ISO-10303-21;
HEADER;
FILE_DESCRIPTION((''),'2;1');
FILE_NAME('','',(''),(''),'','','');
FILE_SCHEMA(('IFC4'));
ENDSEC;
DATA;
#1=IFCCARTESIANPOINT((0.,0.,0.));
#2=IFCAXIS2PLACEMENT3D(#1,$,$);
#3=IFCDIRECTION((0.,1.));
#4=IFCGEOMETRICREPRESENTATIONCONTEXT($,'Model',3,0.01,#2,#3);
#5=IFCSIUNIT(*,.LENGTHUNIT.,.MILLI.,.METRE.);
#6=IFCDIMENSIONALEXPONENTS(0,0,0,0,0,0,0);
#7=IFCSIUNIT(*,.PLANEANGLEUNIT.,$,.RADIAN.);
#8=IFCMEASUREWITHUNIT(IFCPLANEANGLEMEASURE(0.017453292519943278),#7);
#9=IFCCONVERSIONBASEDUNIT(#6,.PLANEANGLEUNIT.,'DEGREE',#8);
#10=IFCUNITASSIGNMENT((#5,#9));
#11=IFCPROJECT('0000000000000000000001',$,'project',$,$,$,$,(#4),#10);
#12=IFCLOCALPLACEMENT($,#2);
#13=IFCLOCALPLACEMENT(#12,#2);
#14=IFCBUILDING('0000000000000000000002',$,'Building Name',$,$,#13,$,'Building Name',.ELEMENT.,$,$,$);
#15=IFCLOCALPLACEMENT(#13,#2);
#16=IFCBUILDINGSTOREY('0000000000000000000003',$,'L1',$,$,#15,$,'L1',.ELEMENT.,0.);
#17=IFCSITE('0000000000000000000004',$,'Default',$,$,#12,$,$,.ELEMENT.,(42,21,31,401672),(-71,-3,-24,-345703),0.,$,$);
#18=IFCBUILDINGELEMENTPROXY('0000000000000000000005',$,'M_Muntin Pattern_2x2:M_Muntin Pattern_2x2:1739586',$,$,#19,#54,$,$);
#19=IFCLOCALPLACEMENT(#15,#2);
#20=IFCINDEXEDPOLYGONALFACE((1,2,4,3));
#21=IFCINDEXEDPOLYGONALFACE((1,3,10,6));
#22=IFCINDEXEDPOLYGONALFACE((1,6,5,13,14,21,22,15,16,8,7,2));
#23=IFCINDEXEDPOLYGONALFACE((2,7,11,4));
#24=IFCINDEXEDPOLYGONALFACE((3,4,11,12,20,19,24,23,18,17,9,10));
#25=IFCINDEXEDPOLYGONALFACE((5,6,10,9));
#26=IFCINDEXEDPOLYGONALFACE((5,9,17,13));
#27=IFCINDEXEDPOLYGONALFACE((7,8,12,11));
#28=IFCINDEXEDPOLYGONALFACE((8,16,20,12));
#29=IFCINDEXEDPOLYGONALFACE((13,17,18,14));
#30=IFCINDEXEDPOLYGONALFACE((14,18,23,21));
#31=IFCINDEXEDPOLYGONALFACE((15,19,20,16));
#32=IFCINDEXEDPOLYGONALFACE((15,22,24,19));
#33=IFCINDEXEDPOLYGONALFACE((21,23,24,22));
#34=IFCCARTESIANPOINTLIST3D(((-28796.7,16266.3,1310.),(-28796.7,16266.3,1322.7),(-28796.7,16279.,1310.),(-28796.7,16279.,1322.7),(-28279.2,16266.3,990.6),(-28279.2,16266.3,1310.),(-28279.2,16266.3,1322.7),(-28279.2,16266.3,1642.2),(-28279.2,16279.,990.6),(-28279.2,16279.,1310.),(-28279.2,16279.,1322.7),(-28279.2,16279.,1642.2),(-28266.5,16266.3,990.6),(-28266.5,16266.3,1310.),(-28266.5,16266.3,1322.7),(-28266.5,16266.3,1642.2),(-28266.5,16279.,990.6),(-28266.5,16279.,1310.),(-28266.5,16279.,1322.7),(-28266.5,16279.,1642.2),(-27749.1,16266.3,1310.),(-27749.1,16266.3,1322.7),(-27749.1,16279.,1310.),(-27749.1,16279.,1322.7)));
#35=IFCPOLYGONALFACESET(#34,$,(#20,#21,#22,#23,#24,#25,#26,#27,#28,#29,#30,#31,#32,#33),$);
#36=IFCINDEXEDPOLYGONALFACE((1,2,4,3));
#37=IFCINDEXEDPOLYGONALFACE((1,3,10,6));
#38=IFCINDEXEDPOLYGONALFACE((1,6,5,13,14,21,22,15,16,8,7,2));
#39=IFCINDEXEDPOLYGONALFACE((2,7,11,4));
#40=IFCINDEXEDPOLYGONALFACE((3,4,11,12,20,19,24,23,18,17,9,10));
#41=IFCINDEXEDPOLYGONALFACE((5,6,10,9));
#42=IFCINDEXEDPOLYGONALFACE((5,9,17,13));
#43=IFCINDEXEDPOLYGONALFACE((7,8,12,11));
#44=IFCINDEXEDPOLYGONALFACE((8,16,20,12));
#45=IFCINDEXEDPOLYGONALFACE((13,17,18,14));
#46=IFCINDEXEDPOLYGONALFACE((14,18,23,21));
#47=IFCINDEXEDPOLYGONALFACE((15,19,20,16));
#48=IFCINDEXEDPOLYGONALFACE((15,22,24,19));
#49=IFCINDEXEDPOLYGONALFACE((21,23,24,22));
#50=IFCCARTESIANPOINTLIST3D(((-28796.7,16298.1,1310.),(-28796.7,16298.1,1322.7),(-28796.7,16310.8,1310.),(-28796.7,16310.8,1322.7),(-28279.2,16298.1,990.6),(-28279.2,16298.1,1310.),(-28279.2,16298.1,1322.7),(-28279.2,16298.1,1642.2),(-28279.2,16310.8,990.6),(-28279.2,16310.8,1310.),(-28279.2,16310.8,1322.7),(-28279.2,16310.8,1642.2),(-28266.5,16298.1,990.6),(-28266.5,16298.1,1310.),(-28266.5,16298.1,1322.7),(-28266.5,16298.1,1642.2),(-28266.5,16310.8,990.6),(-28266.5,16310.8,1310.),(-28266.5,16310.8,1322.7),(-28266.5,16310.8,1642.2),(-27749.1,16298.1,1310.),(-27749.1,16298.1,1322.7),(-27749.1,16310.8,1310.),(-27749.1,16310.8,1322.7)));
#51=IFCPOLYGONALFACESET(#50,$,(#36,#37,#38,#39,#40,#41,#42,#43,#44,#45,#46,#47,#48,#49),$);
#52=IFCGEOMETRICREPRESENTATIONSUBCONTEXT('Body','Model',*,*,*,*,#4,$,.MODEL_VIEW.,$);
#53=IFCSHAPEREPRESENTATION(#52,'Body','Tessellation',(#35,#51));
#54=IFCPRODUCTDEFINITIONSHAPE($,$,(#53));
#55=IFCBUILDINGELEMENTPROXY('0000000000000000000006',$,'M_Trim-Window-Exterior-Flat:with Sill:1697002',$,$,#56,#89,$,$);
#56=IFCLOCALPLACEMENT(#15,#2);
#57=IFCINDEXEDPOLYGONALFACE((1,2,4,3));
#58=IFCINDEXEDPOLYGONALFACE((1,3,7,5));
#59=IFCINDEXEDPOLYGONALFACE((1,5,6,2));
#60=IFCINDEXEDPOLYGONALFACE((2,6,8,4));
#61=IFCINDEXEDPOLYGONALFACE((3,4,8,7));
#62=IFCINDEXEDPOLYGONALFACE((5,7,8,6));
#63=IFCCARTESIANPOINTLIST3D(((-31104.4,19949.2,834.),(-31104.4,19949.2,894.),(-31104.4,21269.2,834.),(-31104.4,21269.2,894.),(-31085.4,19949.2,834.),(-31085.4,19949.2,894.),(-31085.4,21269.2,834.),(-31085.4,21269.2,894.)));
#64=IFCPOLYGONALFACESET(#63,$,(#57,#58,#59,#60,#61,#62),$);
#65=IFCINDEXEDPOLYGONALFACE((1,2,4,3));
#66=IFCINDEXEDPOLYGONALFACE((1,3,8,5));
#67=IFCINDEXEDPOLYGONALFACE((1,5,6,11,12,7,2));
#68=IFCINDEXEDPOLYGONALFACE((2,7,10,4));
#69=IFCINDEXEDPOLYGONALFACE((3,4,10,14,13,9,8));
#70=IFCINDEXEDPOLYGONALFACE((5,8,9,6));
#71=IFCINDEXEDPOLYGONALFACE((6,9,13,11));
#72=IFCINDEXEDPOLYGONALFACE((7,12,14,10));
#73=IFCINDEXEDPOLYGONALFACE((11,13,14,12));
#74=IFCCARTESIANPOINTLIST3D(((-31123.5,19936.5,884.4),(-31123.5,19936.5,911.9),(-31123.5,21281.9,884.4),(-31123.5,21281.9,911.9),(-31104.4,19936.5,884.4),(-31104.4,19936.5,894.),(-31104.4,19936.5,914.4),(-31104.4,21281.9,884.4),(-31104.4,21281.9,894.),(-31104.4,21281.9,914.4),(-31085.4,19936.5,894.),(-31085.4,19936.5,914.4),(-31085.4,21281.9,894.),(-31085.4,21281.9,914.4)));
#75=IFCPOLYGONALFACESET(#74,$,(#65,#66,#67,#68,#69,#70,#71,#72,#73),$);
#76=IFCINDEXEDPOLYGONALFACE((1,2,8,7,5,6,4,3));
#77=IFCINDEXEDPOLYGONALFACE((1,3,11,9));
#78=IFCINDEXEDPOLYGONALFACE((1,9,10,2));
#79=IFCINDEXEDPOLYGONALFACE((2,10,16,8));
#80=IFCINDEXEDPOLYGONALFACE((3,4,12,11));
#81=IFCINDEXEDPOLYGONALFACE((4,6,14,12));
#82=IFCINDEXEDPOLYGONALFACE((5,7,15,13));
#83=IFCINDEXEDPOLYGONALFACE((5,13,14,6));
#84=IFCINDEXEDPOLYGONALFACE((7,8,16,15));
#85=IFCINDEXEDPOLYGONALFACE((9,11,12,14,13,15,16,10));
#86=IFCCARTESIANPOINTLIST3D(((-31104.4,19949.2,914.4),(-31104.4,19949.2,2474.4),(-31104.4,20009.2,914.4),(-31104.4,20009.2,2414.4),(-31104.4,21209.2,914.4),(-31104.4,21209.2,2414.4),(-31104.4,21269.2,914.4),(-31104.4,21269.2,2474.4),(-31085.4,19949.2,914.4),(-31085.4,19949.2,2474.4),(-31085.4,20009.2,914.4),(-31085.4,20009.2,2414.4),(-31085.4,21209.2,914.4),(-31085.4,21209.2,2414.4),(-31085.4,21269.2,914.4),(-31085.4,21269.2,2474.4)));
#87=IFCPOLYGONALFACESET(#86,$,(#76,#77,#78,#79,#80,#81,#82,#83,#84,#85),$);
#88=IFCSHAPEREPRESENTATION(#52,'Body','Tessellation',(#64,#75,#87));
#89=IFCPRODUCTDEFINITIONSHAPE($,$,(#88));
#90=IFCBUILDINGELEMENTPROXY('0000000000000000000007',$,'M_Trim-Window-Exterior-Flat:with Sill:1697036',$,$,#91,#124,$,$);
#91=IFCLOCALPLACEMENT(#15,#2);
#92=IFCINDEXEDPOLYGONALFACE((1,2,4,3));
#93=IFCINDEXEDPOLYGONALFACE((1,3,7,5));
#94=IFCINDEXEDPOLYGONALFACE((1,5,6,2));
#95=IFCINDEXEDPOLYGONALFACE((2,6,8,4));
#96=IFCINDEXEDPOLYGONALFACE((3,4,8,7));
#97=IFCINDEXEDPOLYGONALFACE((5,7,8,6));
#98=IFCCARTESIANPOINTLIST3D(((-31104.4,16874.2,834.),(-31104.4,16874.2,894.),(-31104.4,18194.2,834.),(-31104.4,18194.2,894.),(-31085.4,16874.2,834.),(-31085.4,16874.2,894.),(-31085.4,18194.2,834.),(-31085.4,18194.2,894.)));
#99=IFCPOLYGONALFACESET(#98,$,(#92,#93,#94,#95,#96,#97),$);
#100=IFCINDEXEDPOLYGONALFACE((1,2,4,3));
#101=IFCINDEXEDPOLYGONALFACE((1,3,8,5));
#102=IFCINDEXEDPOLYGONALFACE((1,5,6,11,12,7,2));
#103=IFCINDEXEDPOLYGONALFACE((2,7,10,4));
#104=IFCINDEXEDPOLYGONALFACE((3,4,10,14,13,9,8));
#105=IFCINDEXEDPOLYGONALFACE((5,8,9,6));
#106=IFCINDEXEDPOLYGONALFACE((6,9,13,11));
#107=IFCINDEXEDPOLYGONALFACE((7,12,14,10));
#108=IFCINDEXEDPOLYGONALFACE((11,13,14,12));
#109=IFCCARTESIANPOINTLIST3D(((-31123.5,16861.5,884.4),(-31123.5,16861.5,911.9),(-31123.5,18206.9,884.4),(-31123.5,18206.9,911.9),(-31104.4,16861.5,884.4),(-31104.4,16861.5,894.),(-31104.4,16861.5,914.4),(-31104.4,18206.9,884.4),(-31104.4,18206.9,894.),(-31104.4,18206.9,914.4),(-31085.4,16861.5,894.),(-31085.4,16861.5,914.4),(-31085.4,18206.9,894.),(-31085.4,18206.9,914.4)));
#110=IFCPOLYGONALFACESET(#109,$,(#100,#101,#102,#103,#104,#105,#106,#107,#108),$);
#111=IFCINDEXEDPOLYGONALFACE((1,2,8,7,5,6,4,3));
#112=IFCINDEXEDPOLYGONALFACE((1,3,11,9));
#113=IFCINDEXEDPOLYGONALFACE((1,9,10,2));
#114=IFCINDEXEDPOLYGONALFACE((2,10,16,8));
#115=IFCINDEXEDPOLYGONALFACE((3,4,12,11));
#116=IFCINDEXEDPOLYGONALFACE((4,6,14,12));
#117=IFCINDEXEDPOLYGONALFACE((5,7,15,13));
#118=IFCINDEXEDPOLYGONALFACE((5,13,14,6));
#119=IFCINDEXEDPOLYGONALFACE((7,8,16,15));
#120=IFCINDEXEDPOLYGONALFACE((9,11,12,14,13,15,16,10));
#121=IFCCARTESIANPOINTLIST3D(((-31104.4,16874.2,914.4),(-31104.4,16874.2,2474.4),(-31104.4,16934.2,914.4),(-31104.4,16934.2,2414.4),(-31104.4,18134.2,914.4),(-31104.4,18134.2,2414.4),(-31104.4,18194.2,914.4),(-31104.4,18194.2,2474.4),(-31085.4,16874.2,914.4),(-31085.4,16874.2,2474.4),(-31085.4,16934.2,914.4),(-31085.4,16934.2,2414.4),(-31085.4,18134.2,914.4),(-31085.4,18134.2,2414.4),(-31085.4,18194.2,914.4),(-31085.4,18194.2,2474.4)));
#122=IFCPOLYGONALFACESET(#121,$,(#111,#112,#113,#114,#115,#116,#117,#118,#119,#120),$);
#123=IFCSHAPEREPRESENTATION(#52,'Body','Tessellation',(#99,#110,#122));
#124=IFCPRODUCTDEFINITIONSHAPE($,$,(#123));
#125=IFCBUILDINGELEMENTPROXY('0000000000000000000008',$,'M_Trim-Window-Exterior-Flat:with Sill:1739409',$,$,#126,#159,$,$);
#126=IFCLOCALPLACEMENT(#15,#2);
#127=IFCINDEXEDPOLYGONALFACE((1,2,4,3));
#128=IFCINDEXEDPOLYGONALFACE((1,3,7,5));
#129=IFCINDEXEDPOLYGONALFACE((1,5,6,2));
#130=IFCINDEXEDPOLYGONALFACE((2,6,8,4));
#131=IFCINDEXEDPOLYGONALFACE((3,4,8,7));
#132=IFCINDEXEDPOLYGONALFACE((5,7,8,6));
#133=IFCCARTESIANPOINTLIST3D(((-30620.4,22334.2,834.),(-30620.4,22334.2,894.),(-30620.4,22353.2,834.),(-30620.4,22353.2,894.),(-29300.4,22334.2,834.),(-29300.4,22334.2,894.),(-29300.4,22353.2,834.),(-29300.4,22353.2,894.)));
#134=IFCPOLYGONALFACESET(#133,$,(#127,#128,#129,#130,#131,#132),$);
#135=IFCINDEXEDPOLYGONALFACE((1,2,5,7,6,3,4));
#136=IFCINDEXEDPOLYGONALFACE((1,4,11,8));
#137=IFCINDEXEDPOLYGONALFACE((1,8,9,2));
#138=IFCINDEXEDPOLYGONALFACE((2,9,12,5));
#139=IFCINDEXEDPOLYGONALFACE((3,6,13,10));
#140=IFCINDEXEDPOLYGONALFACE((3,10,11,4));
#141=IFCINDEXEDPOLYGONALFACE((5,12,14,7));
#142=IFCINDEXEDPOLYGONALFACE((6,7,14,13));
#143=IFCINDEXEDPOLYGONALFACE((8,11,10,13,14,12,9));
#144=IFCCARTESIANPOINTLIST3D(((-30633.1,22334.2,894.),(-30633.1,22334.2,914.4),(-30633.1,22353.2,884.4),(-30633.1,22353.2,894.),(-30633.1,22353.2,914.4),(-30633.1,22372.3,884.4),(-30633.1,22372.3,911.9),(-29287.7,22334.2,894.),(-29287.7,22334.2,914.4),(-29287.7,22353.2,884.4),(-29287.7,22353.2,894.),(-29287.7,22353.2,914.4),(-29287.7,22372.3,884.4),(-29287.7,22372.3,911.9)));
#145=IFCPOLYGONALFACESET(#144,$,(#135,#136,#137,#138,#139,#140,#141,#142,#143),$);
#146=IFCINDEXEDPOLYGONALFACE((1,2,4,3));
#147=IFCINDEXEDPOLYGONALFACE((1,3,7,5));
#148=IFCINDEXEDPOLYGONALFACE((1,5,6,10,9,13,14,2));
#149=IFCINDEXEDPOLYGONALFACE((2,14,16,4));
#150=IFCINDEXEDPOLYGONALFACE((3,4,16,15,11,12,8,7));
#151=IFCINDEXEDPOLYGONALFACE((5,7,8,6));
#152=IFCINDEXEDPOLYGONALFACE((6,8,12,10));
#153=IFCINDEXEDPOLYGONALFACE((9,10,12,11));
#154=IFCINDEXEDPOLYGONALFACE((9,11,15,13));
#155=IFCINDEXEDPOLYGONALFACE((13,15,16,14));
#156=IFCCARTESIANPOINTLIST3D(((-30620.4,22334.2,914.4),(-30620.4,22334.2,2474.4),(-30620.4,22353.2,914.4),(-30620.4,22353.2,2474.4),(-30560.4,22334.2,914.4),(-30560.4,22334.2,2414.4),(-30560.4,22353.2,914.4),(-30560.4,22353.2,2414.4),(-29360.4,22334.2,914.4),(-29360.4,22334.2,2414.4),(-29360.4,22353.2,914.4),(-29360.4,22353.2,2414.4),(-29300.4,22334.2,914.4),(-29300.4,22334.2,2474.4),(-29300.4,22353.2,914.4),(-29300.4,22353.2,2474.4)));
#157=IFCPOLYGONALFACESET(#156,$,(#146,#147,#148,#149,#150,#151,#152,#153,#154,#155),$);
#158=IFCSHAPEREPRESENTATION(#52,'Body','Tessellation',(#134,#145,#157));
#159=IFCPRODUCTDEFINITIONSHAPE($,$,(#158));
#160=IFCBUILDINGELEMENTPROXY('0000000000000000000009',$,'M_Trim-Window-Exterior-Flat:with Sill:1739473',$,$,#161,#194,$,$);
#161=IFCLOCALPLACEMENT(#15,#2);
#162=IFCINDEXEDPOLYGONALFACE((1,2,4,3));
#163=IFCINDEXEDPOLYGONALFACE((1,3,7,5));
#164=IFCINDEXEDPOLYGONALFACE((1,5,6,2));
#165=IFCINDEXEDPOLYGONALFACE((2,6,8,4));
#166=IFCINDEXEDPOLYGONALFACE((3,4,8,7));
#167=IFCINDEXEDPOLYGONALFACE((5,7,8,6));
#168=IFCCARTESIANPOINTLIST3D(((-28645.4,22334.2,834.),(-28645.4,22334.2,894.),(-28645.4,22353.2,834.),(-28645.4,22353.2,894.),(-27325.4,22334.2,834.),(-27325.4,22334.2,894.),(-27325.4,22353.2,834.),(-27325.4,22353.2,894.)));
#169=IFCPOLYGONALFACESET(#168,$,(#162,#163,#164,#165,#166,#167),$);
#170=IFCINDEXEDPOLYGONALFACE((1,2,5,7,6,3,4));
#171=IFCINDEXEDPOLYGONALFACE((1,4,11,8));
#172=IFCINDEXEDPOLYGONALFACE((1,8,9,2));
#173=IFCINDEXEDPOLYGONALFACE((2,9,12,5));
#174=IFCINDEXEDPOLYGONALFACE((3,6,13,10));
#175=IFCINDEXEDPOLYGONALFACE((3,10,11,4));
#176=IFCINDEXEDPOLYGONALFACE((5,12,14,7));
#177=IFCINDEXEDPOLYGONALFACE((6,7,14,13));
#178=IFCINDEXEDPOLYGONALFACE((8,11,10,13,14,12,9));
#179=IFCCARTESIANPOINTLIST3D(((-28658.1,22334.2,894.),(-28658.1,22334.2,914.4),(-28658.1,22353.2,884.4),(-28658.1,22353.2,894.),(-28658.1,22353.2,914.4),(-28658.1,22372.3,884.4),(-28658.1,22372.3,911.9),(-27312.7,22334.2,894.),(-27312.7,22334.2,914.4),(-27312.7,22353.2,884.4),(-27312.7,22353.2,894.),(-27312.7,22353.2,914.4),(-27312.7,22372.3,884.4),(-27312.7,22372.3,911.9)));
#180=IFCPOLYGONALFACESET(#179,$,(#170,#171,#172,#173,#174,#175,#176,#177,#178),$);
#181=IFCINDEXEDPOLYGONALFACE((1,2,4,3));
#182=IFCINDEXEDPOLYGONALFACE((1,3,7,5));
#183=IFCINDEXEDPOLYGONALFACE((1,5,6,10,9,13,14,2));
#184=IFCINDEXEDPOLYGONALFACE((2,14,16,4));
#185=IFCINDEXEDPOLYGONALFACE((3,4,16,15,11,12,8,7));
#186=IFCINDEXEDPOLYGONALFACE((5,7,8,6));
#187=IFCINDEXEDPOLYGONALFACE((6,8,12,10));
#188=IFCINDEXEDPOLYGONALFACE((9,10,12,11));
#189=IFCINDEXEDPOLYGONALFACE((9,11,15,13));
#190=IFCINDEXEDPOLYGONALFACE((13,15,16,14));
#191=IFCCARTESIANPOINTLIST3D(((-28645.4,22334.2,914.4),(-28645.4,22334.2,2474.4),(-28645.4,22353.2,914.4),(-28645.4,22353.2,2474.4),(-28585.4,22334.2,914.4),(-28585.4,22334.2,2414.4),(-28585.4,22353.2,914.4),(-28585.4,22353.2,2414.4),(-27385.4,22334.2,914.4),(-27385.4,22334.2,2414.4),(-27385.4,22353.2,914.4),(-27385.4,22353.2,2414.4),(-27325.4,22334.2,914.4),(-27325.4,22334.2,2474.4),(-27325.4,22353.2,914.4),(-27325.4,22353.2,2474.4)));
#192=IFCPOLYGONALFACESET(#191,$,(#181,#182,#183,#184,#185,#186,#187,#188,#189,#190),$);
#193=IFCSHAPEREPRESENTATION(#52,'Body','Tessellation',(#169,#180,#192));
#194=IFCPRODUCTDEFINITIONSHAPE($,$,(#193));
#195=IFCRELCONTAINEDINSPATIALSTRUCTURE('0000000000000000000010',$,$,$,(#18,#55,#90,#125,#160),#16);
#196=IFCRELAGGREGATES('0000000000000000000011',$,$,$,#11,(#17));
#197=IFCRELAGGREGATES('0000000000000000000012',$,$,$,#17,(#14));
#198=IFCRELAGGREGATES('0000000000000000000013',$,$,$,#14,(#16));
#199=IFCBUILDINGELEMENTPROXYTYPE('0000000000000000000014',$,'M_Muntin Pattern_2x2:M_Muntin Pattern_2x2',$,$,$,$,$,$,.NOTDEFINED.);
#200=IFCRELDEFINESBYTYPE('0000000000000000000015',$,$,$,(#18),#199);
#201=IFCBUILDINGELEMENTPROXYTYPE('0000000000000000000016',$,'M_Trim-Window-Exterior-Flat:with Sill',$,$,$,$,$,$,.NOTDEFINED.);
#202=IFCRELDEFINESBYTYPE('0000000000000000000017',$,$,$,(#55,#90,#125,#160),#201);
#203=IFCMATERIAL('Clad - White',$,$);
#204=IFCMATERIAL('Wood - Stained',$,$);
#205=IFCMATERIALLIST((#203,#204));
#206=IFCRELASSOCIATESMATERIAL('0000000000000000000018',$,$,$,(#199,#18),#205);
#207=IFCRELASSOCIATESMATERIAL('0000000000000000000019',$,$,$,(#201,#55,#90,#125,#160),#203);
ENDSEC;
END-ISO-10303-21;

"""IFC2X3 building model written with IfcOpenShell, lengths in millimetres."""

from ifc_helpers import new_model, entity, si_unit, converted_unit, direction, frame, frame_2d, origin, place, context, subcontext, project, spatial, polyline, rectangle, outline, extrude, source, transform, mapped, material, material_list, type_object, type_shapes, element, save


model = new_model("IFC2X3")

# Units and contexts
model_context = context("Model", 3, precision=0.01, world=origin(), true_north=direction((0.0, 1.0)))
body_context = subcontext(model_context, "Body", "Model", "MODEL_VIEW")
ifc_project = project(units=[si_unit("LENGTHUNIT", "METRE", prefix="MILLI"), converted_unit("PLANEANGLEUNIT", "DEGREE", entity("IfcPlaneAngleMeasure", 0.017453292519943278), si_unit("PLANEANGLEUNIT", "RADIAN"), dimensions=[0, 0, 0, 0, 0, 0, 0])], contexts=[model_context])

# Site, building, storey
site_placement = place(None, origin())
site = spatial("IfcSite", under=ifc_project, at=site_placement, Name="Default", CompositionType="ELEMENT", RefLatitude=(42, 21, 31, 401672), RefLongitude=(-71, -3, -24, -345703), RefElevation=0.0)
building_placement = place(site_placement, origin())
building = spatial("IfcBuilding", under=site, at=building_placement, Name="Building Name", LongName="Building Name", CompositionType="ELEMENT")
storey_placement = place(building_placement, origin())
storey = spatial("IfcBuildingStorey", under=building, at=storey_placement, Name="L1", LongName="L1", CompositionType="ELEMENT", Elevation=0.0)

# Shared definitions
ifc_material_1 = material(Name="Wood - Stained")

# Building element proxies
ifc_material_2 = material(Name="Clad - White")
ifc_material_list_1 = material_list([ifc_material_2, ifc_material_1])
building_element_proxy_type_1 = type_object("IfcBuildingElementProxyType", Name="M_Muntin Pattern_2x2:M_Muntin Pattern_2x2", PredefinedType="NOTDEFINED", material=ifc_material_list_1)
shared_shape_1 = source(origin(), body_context, "Body", "SweptSolid", [
    extrude(outline(polyline([(6.4, -6.4), (325.8, -6.4), (325.8, 6.3), (6.4, 6.3), (6.4, 523.8), (-6.3, 523.8), (-6.3, 6.3), (-325.8, 6.3), (-325.8, -6.4), (-6.3, -6.4), (-6.3, -523.8), (6.4, -523.8), (6.4, -6.4)])), frame((0.0, 9.5, 325.8), z_axis=(0.0, 1.0, 0.0), x_axis=(0.0, 0.0, 1.0)), (0.0, 0.0, 1.0), 12.7),
    extrude(outline(polyline([(6.4, -6.4), (325.8, -6.4), (325.8, 6.3), (6.4, 6.3), (6.4, 523.8), (-6.3, 523.8), (-6.3, 6.3), (-325.8, 6.3), (-325.8, -6.4), (-6.3, -6.4), (-6.3, -523.8), (6.4, -523.8), (6.4, -6.4)])), frame((0.0, -22.2, 325.8), z_axis=(0.0, 1.0, 0.0), x_axis=(0.0, 0.0, 1.0)), (0.0, 0.0, 1.0), 12.7),
])
type_shapes(building_element_proxy_type_1, [shared_shape_1])
for number, where, z_axis, x_axis, name in (
    (1, (-28272.9, 16288.6, 990.6), (0.0, 0.0, 1.0), (-1.0, 0.0, 0.0), "M_Muntin Pattern_2x2:M_Muntin Pattern_2x2:1739586"),
):
    element("IfcBuildingElementProxy", number, at=place(storey_placement, frame(where, z_axis=z_axis, x_axis=x_axis)), inside=storey, type_object=building_element_proxy_type_1, material=ifc_material_list_1, Name=name, context=body_context, shape_type="MappedRepresentation", body=[
        mapped(shared_shape_1, transform((0.0, 0.0, 0.0), scale=1.0)),
    ])
building_element_proxy_type_2 = type_object("IfcBuildingElementProxyType", Name="M_Trim-Window-Exterior-Flat:with Sill", PredefinedType="NOTDEFINED", material=ifc_material_2)
shared_shape_2 = source(origin(), body_context, "Body", "SweptSolid", [
    extrude(rectangle(XDim=1320.0, YDim=60.0, at=frame_2d((0.0, 0.0), x_axis=(1.0, 0.0))), frame((0.0, -1550.4, 0.0), z_axis=(0.0, 0.0, 1.0), x_axis=(-1.0, 0.0, 0.0)), (0.0, 0.0, 1.0), 19.0),
    extrude(outline(polyline([(-19.0, -15.2), (0.0, -15.2), (0.0, -5.7), (19.0, -5.7), (19.0, 14.8), (0.0, 14.8), (-19.0, 12.3), (-19.0, -15.2)])), frame((-672.7, -1514.8, 19.0), z_axis=(1.0, 0.0, 0.0), x_axis=(0.0, 0.0, -1.0)), (0.0, 0.0, 1.0), 1345.4),
    extrude(outline(polyline([(-795.0, -660.0), (765.0, -660.0), (765.0, -600.0), (-735.0, -600.0), (-735.0, 600.0), (765.0, 600.0), (765.0, 660.0), (-795.0, 660.0), (-795.0, -660.0)])), frame((0.0, -735.0, 0.0), z_axis=(0.0, 0.0, 1.0), x_axis=(0.0, -1.0, 0.0)), (0.0, 0.0, 1.0), 19.0),
])
type_shapes(building_element_proxy_type_2, [shared_shape_2])
for number, where, z_axis, x_axis, name in (
    (2, (-31085.4, 20609.2, 2414.4), (-1.0, 0.0, 0.0), (0.0, -1.0, 0.0), "M_Trim-Window-Exterior-Flat:with Sill:1697002"),
    (3, (-31085.4, 17534.2, 2414.4), (-1.0, 0.0, 0.0), (0.0, -1.0, 0.0), "M_Trim-Window-Exterior-Flat:with Sill:1697036"),
    (4, (-29960.4, 22334.2, 2414.4), (0.0, 1.0, 0.0), (-1.0, 0.0, 0.0), "M_Trim-Window-Exterior-Flat:with Sill:1739409"),
    (5, (-27985.4, 22334.2, 2414.4), (0.0, 1.0, 0.0), (-1.0, 0.0, 0.0), "M_Trim-Window-Exterior-Flat:with Sill:1739473"),
):
    element("IfcBuildingElementProxy", number, at=place(storey_placement, frame(where, z_axis=z_axis, x_axis=x_axis)), inside=storey, type_object=building_element_proxy_type_2, material=ifc_material_2, Name=name, context=body_context, shape_type="MappedRepresentation", body=[
        mapped(shared_shape_2, transform((0.0, 0.0, 0.0), scale=1.0)),
    ])

save(model, "model.ifc")
